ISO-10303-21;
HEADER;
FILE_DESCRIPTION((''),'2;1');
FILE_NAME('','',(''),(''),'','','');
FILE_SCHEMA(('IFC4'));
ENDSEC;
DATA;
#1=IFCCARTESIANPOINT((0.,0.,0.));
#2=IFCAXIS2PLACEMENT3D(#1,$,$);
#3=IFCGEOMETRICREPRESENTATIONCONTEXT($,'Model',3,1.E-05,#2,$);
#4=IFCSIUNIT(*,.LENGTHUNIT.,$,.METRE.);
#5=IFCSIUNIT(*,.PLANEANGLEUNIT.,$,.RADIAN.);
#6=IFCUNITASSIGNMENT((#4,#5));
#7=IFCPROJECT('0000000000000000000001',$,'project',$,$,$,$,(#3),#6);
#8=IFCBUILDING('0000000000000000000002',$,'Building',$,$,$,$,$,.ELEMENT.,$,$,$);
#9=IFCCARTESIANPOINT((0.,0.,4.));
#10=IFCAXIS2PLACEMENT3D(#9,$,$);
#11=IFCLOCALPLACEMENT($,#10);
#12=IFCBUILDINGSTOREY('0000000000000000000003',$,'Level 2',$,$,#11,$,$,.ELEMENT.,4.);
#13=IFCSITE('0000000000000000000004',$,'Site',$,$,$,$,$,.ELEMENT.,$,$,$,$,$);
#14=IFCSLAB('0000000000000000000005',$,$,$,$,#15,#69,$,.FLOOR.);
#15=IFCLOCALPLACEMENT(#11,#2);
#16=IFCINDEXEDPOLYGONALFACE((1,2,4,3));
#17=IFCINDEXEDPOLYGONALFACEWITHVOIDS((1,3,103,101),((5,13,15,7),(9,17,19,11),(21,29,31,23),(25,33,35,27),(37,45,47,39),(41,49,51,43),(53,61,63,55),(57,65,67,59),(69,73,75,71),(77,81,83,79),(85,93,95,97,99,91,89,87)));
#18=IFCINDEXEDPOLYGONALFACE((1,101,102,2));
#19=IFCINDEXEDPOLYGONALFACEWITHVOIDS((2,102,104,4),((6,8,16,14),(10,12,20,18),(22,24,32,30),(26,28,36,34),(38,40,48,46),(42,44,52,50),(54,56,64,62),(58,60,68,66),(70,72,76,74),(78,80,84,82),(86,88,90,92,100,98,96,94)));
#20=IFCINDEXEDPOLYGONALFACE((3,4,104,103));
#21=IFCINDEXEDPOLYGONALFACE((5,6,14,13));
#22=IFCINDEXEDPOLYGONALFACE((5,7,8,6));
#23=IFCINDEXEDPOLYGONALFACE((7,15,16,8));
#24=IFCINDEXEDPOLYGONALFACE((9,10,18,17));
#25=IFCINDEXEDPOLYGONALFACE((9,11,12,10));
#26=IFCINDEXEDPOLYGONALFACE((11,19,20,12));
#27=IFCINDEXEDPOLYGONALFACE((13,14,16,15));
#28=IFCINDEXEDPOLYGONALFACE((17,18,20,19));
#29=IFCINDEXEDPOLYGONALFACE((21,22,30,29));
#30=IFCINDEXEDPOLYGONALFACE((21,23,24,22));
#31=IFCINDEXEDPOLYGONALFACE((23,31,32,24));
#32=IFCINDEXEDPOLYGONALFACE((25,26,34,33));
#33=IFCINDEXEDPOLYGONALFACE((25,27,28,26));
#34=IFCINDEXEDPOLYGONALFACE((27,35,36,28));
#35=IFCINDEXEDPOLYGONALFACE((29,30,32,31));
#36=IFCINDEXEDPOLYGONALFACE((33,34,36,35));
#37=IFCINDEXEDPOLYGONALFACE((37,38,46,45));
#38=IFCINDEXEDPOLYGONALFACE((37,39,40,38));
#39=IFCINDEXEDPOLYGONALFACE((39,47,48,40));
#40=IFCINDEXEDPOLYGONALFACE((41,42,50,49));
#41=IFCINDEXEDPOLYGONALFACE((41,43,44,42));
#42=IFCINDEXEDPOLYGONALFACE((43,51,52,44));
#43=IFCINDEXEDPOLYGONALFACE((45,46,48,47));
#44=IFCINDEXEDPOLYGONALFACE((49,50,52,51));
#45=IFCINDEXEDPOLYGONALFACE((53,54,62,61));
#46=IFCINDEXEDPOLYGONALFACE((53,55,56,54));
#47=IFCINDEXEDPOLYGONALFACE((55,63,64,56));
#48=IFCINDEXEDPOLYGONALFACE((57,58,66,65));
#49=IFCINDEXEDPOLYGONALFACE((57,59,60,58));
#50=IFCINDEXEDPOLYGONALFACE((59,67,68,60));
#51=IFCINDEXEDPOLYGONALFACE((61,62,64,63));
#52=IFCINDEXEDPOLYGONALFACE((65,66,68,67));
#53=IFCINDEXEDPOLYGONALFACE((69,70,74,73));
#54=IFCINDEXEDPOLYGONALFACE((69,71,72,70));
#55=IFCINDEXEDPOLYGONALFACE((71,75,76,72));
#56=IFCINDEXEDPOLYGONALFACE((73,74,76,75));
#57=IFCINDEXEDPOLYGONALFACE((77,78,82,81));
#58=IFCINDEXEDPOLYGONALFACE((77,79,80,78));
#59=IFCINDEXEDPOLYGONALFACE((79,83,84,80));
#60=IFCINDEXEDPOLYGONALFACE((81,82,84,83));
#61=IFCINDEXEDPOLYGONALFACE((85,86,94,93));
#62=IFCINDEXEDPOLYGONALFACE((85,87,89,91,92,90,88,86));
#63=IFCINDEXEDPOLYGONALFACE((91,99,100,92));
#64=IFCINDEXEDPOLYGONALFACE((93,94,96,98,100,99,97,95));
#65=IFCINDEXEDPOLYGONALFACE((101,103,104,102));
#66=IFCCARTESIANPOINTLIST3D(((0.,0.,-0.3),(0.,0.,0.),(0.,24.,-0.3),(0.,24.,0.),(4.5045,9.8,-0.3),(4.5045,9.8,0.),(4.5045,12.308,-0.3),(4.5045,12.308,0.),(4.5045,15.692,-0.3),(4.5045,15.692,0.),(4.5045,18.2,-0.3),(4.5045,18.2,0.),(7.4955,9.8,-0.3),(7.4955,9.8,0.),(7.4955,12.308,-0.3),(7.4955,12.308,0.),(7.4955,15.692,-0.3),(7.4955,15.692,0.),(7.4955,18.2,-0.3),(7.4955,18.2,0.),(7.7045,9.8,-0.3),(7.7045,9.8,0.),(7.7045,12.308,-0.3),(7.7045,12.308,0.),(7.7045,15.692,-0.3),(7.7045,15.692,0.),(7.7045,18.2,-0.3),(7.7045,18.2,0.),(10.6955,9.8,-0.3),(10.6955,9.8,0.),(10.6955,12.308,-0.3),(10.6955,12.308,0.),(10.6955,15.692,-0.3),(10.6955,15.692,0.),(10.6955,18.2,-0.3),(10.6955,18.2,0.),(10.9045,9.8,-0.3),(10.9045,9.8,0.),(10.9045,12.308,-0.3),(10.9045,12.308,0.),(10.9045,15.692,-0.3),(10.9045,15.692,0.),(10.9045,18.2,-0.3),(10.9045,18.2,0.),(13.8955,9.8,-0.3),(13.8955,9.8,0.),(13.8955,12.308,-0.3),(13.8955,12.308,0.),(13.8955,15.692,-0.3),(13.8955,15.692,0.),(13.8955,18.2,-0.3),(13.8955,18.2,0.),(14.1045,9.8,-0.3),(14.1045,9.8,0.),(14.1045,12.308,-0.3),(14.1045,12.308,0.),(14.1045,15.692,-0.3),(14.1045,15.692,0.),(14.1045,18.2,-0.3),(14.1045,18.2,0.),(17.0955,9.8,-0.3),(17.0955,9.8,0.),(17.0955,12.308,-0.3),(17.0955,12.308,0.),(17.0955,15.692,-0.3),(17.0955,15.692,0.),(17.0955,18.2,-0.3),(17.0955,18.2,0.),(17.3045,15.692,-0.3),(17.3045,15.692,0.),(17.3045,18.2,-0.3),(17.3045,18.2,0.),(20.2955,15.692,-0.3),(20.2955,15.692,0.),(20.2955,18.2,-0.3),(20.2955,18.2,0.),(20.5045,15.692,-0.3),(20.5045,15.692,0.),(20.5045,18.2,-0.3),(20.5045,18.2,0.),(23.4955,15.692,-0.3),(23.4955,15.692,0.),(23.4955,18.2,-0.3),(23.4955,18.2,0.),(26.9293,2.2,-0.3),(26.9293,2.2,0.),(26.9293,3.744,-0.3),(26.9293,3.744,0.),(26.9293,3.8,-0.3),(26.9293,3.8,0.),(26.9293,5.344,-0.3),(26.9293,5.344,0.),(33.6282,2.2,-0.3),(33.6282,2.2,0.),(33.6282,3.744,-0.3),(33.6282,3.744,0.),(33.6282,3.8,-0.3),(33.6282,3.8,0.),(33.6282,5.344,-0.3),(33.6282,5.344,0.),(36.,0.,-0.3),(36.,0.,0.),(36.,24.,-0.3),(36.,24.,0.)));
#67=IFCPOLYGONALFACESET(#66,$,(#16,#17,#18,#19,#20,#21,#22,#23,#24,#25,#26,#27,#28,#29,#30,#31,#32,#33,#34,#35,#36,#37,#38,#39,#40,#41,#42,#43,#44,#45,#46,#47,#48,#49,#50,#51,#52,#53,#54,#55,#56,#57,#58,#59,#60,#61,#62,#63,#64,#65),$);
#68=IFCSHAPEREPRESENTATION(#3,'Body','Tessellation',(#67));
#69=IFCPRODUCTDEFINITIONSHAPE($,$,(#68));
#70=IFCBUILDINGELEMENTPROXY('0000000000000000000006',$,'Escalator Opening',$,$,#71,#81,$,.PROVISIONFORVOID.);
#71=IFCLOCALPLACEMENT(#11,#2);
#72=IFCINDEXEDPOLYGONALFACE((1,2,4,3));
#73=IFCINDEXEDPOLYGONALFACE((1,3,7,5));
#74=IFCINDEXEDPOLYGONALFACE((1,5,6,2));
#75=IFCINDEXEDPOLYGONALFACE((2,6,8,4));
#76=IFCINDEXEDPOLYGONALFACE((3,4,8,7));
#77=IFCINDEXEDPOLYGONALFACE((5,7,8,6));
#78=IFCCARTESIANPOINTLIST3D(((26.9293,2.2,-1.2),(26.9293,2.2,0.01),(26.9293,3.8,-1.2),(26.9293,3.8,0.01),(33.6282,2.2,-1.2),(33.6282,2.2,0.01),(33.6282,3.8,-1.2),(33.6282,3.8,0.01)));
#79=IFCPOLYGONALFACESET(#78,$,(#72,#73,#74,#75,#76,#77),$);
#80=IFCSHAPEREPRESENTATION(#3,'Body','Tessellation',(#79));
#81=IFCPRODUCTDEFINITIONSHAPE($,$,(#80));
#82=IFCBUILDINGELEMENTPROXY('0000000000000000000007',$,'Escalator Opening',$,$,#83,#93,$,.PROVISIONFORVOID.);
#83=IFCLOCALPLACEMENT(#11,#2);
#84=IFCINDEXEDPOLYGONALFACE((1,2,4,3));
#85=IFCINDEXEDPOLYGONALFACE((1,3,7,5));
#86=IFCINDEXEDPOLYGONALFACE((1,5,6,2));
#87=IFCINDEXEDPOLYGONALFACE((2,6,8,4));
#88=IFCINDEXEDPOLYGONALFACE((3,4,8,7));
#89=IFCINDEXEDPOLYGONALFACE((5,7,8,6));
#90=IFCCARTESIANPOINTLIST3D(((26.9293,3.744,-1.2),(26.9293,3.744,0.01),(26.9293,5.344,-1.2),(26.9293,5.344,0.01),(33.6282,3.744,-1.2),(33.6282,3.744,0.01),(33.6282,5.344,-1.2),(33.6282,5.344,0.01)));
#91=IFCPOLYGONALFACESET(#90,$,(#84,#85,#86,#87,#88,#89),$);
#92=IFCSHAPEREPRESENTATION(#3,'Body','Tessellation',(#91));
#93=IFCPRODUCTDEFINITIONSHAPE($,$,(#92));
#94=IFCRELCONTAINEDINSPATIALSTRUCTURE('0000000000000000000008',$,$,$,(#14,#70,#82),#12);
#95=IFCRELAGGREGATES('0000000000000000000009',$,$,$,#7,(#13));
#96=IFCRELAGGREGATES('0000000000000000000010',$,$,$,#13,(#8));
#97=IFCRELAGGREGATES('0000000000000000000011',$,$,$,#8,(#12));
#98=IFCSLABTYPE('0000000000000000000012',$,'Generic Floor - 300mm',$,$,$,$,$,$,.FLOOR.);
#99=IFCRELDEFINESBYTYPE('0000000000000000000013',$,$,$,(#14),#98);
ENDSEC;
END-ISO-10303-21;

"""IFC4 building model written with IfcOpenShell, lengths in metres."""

from ifc_helpers import new_model, si_unit, frame, origin, place, context, project, spatial, polyline, outline, extrude, type_object, element, save


model = new_model("IFC4")

# Units and contexts
model_context = context("Model", 3, precision=1e-05, world=origin())
ifc_project = project(units=[si_unit("LENGTHUNIT", "METRE"), si_unit("PLANEANGLEUNIT", "RADIAN")], contexts=[model_context])

# Site, building, storey
site = spatial("IfcSite", under=ifc_project, Name="Site", CompositionType="ELEMENT")
building = spatial("IfcBuilding", under=site, Name="Building", CompositionType="ELEMENT")
storey_placement = place(None, frame((0.0, 0.0, 4.0)))
storey = spatial("IfcBuildingStorey", under=building, at=storey_placement, Name="Level 2", CompositionType="ELEMENT", Elevation=4.0)

# Slab, openings
slab_type = type_object("IfcSlabType", Name="Generic Floor - 300mm", PredefinedType="FLOOR")
slab_placement = place(None, frame((0.0, 0.0, 4.0)))
slab = element("IfcSlab", 1, at=slab_placement, inside=storey, type_object=slab_type, PredefinedType="FLOOR", context=model_context, shape_type="SweptSolid", body=[
    extrude(outline(polyline([(0.0, 0.0), (36.0, 0.0), (36.0, 24.0), (0.0, 24.0), (0.0, 0.0)])), origin(), (0.0, 0.0, -1.0), 0.3),
])
opening_1_placement = place(None, frame((0.0, 0.0, 4.001)))
element("IfcOpeningElement", 2, at=opening_1_placement, cuts=slab, PredefinedType="OPENING", context=model_context, shape_type="SweptSolid", body=[
    extrude(outline(polyline([(4.5045, 9.8), (7.4955, 9.8), (7.4955, 12.308), (4.5045, 12.308), (4.5045, 9.8)])), origin(), (0.0, 0.0, -1.0), 0.302),
])
opening_2_placement = place(None, frame((0.0, 0.0, 4.001)))
element("IfcOpeningElement", 3, at=opening_2_placement, cuts=slab, PredefinedType="OPENING", context=model_context, shape_type="SweptSolid", body=[
    extrude(outline(polyline([(7.7045, 9.8), (10.6955, 9.8), (10.6955, 12.308), (7.7045, 12.308), (7.7045, 9.8)])), origin(), (0.0, 0.0, -1.0), 0.302),
])
opening_3_placement = place(None, frame((0.0, 0.0, 4.001)))
element("IfcOpeningElement", 4, at=opening_3_placement, cuts=slab, PredefinedType="OPENING", context=model_context, shape_type="SweptSolid", body=[
    extrude(outline(polyline([(10.9045, 9.8), (13.8955, 9.8), (13.8955, 12.308), (10.9045, 12.308), (10.9045, 9.8)])), origin(), (0.0, 0.0, -1.0), 0.302),
])
opening_4_placement = place(None, frame((0.0, 0.0, 4.001)))
element("IfcOpeningElement", 5, at=opening_4_placement, cuts=slab, PredefinedType="OPENING", context=model_context, shape_type="SweptSolid", body=[
    extrude(outline(polyline([(14.1045, 9.8), (17.0955, 9.8), (17.0955, 12.308), (14.1045, 12.308), (14.1045, 9.8)])), origin(), (0.0, 0.0, -1.0), 0.302),
])
opening_5_placement = place(None, frame((0.0, 0.0, 4.001)))
element("IfcOpeningElement", 6, at=opening_5_placement, cuts=slab, PredefinedType="OPENING", context=model_context, shape_type="SweptSolid", body=[
    extrude(outline(polyline([(7.4955, 18.2), (4.5045, 18.2), (4.5045, 15.692), (7.4955, 15.692), (7.4955, 18.2)])), origin(), (0.0, 0.0, -1.0), 0.302),
])
opening_6_placement = place(None, frame((0.0, 0.0, 4.001)))
element("IfcOpeningElement", 7, at=opening_6_placement, cuts=slab, PredefinedType="OPENING", context=model_context, shape_type="SweptSolid", body=[
    extrude(outline(polyline([(10.6955, 18.2), (7.7045, 18.2), (7.7045, 15.692), (10.6955, 15.692), (10.6955, 18.2)])), origin(), (0.0, 0.0, -1.0), 0.302),
])
opening_7_placement = place(None, frame((0.0, 0.0, 4.001)))
element("IfcOpeningElement", 8, at=opening_7_placement, cuts=slab, PredefinedType="OPENING", context=model_context, shape_type="SweptSolid", body=[
    extrude(outline(polyline([(13.8955, 18.2), (10.9045, 18.2), (10.9045, 15.692), (13.8955, 15.692), (13.8955, 18.2)])), origin(), (0.0, 0.0, -1.0), 0.302),
])
opening_8_placement = place(None, frame((0.0, 0.0, 4.001)))
element("IfcOpeningElement", 9, at=opening_8_placement, cuts=slab, PredefinedType="OPENING", context=model_context, shape_type="SweptSolid", body=[
    extrude(outline(polyline([(17.0955, 18.2), (14.1045, 18.2), (14.1045, 15.692), (17.0955, 15.692), (17.0955, 18.2)])), origin(), (0.0, 0.0, -1.0), 0.302),
])
opening_9_placement = place(None, frame((0.0, 0.0, 4.001)))
element("IfcOpeningElement", 10, at=opening_9_placement, cuts=slab, PredefinedType="OPENING", context=model_context, shape_type="SweptSolid", body=[
    extrude(outline(polyline([(20.2955, 18.2), (17.3045, 18.2), (17.3045, 15.692), (20.2955, 15.692), (20.2955, 18.2)])), origin(), (0.0, 0.0, -1.0), 0.302),
])
opening_10_placement = place(None, frame((0.0, 0.0, 4.001)))
element("IfcOpeningElement", 11, at=opening_10_placement, cuts=slab, PredefinedType="OPENING", context=model_context, shape_type="SweptSolid", body=[
    extrude(outline(polyline([(23.4955, 18.2), (20.5045, 18.2), (20.5045, 15.692), (23.4955, 15.692), (23.4955, 18.2)])), origin(), (0.0, 0.0, -1.0), 0.302),
])
opening_11_placement = place(None, frame((0.0, 0.0, 4.001)))
element("IfcOpeningElement", 12, at=opening_11_placement, cuts=slab, PredefinedType="OPENING", context=model_context, shape_type="SweptSolid", body=[
    extrude(outline(polyline([(26.9293, 2.2), (33.6282, 2.2), (33.6282, 3.8), (26.9293, 3.8), (26.9293, 2.2)])), origin(), (0.0, 0.0, -1.0), 0.302),
])
opening_12_placement = place(None, frame((0.0, 0.0, 4.001)))
element("IfcOpeningElement", 13, at=opening_12_placement, cuts=slab, PredefinedType="OPENING", context=model_context, shape_type="SweptSolid", body=[
    extrude(outline(polyline([(26.9293, 3.744), (33.6282, 3.744), (33.6282, 5.344), (26.9293, 5.344), (26.9293, 3.744)])), origin(), (0.0, 0.0, -1.0), 0.302),
])

# Building element proxies
proxy_1_placement = place(None, frame((0.0, 0.0, 4.01)))
element("IfcBuildingElementProxy", 14, at=proxy_1_placement, inside=storey, Name="Escalator Opening", PredefinedType="PROVISIONFORVOID", context=model_context, shape_type="SweptSolid", body=[
    extrude(outline(polyline([(26.9293, 2.2), (33.6282, 2.2), (33.6282, 3.8), (26.9293, 3.8), (26.9293, 2.2)])), origin(), (0.0, 0.0, -1.0), 1.21),
])
proxy_2_placement = place(None, frame((0.0, 0.0, 4.01)))
element("IfcBuildingElementProxy", 15, at=proxy_2_placement, inside=storey, Name="Escalator Opening", PredefinedType="PROVISIONFORVOID", context=model_context, shape_type="SweptSolid", body=[
    extrude(outline(polyline([(26.9293, 3.744), (33.6282, 3.744), (33.6282, 5.344), (26.9293, 5.344), (26.9293, 3.744)])), origin(), (0.0, 0.0, -1.0), 1.21),
])

save(model, "model.ifc")
